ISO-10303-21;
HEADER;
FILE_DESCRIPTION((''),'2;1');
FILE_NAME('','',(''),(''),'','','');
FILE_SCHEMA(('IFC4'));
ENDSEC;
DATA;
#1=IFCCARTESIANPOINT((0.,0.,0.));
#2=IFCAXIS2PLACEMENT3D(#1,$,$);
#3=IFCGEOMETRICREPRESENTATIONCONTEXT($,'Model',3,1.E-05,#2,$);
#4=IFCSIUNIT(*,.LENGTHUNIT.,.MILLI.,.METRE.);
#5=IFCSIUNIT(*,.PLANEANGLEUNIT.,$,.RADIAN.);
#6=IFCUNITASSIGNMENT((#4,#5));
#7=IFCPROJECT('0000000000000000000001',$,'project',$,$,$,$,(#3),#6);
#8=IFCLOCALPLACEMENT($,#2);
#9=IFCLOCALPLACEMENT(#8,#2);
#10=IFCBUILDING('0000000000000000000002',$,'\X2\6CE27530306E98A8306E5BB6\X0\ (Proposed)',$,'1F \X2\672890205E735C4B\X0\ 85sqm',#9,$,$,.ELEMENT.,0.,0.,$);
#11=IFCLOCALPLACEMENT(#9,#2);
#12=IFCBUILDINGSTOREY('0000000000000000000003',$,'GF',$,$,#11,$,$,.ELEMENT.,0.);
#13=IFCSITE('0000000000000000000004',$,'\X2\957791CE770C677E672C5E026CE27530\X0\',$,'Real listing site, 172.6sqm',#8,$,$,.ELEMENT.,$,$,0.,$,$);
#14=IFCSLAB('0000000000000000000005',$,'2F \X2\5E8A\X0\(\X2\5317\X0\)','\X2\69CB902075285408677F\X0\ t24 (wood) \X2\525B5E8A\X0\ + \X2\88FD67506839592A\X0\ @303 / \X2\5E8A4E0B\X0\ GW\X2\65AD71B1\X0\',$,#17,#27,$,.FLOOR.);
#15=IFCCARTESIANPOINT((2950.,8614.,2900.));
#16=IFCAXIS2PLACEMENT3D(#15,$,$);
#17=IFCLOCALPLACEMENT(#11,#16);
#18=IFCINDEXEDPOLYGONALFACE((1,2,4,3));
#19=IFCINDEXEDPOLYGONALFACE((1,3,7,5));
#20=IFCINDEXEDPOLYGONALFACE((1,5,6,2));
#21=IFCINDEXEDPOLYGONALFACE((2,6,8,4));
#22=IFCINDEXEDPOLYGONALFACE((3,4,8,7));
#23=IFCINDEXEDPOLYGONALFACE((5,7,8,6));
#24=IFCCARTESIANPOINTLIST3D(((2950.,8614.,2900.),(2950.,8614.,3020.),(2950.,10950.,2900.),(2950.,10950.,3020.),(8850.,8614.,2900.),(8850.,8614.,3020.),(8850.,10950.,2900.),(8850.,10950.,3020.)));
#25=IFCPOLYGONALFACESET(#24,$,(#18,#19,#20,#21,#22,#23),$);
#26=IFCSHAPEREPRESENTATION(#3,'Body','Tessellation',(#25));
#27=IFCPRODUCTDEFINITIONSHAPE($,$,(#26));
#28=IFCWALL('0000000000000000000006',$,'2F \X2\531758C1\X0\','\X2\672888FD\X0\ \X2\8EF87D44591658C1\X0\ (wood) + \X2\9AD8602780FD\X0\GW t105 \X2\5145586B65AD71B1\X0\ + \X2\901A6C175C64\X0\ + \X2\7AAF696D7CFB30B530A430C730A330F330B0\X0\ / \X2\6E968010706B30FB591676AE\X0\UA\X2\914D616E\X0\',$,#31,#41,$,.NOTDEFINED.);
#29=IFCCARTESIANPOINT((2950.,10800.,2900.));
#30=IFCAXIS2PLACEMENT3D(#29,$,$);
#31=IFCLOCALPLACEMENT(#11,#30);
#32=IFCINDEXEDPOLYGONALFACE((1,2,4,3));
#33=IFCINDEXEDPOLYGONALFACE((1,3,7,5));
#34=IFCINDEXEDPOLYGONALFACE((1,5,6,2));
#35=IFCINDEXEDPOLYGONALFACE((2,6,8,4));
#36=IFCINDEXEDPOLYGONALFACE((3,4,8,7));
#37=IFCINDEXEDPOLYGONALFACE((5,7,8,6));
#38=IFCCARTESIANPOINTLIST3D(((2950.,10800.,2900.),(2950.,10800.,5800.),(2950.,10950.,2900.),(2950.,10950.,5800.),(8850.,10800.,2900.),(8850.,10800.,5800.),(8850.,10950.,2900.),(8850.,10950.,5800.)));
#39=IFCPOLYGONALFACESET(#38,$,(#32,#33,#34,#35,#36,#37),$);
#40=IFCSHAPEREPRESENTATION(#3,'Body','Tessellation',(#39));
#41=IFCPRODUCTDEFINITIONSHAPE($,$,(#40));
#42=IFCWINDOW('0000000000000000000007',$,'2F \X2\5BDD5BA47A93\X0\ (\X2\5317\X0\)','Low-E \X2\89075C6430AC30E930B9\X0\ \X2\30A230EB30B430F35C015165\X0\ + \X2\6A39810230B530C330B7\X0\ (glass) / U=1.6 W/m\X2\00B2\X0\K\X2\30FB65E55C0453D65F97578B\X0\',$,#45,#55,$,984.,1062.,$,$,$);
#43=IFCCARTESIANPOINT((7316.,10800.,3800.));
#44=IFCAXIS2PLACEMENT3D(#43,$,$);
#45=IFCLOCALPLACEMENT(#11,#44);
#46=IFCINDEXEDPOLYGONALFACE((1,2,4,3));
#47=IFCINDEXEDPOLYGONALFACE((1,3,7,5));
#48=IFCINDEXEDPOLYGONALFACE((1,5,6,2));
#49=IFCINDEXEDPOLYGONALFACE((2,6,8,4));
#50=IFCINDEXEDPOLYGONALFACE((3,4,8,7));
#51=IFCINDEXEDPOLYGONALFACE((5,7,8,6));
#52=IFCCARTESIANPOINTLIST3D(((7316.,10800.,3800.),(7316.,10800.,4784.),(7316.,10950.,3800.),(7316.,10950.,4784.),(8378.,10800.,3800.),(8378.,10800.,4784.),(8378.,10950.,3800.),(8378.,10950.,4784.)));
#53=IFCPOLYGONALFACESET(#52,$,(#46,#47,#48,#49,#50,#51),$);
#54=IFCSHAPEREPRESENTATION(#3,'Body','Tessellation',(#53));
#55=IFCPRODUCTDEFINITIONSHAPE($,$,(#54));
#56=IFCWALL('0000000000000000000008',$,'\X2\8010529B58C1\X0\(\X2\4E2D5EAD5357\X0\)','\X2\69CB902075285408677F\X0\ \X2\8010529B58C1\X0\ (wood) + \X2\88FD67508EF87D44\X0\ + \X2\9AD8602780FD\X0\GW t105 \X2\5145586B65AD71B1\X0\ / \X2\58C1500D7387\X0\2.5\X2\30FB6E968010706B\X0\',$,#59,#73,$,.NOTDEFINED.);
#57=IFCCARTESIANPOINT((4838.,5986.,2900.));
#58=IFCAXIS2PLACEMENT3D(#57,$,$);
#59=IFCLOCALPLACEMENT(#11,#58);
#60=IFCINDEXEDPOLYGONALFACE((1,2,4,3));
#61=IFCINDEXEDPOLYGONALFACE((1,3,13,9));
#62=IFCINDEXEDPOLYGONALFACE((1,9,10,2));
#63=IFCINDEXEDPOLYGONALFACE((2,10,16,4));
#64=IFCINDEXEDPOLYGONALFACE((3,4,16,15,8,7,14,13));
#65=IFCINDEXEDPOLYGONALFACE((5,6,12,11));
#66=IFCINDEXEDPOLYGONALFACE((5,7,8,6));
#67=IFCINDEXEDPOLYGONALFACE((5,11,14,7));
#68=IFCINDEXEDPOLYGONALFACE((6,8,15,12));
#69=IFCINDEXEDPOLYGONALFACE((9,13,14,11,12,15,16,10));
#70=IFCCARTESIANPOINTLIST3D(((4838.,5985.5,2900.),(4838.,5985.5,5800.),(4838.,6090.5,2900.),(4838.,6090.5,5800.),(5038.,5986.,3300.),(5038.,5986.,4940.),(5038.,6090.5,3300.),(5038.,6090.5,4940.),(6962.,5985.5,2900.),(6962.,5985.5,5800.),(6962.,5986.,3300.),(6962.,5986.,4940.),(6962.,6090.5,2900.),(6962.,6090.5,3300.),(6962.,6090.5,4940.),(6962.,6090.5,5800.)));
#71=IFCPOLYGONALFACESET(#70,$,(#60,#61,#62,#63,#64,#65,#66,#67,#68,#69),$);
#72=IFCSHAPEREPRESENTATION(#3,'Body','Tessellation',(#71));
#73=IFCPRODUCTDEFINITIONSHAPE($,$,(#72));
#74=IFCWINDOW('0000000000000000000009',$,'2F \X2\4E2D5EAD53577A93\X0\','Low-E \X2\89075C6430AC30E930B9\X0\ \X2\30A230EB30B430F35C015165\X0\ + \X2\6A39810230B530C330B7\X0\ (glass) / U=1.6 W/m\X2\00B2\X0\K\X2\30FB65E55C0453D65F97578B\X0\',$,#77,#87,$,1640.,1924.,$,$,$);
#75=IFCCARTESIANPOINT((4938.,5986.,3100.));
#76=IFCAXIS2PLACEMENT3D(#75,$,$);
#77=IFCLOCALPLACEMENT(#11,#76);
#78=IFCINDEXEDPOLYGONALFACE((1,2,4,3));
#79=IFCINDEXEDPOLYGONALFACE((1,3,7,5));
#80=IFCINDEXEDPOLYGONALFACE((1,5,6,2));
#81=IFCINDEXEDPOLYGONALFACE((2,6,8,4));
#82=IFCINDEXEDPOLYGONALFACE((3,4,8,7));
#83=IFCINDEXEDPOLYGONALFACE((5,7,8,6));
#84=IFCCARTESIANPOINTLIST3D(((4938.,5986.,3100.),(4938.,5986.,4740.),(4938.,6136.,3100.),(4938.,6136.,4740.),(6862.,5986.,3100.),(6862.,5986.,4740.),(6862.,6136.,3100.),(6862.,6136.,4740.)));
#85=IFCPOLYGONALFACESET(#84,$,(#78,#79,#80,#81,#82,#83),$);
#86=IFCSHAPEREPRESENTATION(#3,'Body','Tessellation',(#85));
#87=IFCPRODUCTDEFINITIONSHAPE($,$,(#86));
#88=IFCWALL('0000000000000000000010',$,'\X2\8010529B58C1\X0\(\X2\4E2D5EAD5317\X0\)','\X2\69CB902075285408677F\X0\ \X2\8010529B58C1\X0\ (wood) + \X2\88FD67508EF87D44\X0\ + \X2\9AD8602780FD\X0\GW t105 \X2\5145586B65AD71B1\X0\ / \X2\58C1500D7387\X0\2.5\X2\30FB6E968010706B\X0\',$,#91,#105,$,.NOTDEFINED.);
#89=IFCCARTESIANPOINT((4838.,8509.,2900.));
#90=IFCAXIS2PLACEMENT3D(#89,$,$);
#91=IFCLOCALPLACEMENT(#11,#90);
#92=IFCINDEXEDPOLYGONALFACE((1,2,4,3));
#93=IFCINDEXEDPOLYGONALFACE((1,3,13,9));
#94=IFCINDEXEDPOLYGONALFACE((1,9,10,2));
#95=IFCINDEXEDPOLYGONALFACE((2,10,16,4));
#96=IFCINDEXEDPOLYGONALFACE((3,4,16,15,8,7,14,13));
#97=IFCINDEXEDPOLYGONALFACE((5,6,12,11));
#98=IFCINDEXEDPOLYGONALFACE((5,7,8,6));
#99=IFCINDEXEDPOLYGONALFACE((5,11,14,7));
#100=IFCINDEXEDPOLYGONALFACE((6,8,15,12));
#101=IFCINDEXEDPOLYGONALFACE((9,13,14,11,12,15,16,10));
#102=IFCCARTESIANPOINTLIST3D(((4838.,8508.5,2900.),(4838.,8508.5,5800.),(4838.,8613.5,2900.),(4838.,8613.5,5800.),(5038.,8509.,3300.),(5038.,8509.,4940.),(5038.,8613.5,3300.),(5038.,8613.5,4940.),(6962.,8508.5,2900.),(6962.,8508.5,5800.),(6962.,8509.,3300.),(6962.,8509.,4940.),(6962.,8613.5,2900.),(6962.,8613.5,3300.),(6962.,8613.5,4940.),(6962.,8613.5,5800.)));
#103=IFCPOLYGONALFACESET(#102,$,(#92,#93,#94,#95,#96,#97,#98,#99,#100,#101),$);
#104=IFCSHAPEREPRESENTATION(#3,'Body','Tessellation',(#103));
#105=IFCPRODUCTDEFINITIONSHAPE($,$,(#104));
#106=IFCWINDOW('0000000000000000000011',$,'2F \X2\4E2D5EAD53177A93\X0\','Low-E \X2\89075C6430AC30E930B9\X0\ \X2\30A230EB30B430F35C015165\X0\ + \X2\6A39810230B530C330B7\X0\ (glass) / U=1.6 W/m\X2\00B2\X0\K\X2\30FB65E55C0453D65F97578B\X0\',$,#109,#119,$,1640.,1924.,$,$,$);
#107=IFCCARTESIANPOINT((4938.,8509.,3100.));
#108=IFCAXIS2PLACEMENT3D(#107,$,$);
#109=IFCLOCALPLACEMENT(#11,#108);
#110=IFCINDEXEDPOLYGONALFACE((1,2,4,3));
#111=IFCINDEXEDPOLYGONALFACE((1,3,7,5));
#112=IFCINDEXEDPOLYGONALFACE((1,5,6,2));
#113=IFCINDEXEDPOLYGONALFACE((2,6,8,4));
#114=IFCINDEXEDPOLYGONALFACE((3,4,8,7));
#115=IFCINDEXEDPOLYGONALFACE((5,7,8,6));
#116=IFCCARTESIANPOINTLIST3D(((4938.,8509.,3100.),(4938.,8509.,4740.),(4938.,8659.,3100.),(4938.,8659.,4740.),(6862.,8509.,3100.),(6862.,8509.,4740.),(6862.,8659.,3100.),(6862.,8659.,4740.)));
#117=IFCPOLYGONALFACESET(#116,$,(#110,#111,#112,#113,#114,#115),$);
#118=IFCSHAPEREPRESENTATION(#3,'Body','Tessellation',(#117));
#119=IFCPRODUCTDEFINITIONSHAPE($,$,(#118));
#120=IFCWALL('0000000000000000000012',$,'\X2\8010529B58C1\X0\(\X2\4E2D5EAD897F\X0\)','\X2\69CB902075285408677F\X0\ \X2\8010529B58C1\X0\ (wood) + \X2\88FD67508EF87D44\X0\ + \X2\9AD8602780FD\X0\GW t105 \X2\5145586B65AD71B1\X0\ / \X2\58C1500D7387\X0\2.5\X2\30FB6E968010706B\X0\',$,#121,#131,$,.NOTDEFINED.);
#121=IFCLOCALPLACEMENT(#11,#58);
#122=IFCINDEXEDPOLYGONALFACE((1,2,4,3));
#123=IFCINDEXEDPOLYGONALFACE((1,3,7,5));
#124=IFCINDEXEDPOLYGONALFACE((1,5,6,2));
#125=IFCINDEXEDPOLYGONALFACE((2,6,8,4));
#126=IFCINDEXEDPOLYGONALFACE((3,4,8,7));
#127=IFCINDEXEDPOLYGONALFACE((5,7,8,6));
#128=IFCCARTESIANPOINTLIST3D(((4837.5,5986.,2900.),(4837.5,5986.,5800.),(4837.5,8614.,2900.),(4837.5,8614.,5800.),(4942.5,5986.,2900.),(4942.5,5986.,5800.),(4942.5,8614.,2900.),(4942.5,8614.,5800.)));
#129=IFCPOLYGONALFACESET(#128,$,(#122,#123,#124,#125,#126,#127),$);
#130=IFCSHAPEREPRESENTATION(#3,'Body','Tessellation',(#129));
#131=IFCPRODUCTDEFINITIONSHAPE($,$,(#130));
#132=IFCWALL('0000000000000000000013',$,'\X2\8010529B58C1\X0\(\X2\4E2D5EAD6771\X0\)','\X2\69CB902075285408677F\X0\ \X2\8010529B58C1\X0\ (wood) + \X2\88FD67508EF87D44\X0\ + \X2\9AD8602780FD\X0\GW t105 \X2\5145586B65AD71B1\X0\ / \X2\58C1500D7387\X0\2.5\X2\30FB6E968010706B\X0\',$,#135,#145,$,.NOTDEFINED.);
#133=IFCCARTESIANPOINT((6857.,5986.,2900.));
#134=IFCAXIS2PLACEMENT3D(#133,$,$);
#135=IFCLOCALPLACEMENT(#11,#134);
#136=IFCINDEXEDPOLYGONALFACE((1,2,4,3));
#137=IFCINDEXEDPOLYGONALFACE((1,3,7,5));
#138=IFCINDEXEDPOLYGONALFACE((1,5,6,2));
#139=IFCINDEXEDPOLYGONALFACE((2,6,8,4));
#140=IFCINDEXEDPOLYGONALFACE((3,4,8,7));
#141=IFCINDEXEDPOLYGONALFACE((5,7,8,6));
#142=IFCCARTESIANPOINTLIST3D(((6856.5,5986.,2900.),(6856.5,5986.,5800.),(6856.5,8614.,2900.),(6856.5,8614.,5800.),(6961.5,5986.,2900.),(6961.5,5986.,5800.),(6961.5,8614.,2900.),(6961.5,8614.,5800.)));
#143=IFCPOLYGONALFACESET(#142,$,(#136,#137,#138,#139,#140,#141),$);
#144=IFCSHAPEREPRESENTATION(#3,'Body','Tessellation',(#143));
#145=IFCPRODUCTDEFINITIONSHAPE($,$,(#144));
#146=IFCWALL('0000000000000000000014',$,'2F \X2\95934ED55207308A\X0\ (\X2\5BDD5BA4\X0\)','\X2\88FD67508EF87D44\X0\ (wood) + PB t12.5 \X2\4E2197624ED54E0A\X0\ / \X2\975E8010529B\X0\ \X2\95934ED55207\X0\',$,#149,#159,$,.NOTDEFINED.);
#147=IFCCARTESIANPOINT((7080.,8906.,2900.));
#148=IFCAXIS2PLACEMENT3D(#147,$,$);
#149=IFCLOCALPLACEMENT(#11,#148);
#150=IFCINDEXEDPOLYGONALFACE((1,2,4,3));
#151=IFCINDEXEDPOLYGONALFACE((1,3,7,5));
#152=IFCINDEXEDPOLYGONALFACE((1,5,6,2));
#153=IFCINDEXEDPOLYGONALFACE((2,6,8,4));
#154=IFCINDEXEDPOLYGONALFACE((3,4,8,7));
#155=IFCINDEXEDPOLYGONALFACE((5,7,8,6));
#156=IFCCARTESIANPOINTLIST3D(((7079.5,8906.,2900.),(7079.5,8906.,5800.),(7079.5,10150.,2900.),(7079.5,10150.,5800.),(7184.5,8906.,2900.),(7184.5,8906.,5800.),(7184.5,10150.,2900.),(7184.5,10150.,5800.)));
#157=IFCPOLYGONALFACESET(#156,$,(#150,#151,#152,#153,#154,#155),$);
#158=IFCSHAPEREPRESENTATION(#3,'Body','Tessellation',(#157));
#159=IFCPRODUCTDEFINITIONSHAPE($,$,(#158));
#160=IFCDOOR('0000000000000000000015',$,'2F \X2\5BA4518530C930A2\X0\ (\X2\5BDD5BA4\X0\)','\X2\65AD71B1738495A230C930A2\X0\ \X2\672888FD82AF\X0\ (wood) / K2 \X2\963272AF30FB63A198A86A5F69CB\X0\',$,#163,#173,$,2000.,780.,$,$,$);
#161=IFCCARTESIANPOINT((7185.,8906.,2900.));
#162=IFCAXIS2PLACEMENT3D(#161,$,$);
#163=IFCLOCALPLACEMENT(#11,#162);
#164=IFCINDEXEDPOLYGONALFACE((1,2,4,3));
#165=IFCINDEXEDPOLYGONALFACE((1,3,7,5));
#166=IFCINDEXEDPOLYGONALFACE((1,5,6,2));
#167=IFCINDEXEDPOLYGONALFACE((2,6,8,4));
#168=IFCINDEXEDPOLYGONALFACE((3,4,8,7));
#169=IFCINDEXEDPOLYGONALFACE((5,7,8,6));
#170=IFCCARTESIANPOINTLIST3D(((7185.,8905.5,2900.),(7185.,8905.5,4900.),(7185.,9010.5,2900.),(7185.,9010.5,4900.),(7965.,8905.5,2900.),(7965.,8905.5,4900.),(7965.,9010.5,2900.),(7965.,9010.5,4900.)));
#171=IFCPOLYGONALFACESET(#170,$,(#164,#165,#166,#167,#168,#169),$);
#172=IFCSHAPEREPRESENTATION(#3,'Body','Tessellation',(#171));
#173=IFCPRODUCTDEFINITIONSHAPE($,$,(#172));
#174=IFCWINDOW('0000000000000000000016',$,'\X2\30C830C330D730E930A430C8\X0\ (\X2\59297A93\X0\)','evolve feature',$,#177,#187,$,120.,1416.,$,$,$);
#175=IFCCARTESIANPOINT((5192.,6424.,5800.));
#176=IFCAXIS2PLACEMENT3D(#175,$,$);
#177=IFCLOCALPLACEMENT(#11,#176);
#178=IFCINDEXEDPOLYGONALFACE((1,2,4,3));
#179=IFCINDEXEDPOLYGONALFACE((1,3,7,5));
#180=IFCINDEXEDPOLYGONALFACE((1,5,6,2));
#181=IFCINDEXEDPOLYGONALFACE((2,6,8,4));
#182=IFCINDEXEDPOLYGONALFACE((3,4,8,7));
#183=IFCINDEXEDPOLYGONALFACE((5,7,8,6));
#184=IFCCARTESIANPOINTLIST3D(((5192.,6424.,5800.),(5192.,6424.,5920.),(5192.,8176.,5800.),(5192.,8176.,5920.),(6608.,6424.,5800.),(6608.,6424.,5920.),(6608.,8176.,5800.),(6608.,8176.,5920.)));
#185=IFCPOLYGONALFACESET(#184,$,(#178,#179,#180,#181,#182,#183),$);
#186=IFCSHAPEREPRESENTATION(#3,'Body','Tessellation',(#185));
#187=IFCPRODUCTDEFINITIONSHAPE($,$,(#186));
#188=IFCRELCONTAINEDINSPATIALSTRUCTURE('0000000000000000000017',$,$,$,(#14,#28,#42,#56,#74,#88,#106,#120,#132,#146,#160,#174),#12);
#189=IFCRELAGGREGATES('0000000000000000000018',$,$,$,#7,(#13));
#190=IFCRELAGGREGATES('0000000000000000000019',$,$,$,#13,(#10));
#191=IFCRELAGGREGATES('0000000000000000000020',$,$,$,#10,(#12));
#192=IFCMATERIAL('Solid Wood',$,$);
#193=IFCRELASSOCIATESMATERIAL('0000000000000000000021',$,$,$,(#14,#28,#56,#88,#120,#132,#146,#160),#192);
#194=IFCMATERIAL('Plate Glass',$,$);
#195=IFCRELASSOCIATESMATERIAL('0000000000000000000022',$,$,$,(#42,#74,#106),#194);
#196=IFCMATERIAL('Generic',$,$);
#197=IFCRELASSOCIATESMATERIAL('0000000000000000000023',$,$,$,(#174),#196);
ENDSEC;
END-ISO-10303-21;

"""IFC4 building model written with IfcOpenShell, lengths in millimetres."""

from ifc_helpers import new_model, si_unit, frame, frame_2d, origin, place, context, project, spatial, rectangle, extrude, material, element, fill, save


model = new_model("IFC4")

# Units and contexts
model_context = context("Model", 3, precision=1e-05, world=origin())
ifc_project = project(units=[si_unit("LENGTHUNIT", "METRE", prefix="MILLI"), si_unit("PLANEANGLEUNIT", "RADIAN")], contexts=[model_context])

# Site, building, storey
site_placement = place(None, origin())
site = spatial("IfcSite", under=ifc_project, at=site_placement, Name="長野県松本市波田", ObjectType="Real listing site, 172.6sqm", CompositionType="ELEMENT", RefElevation=0.0)
building_placement = place(site_placement, origin())
building = spatial("IfcBuilding", under=site, at=building_placement, Name="波田の風の家 (Proposed)", ObjectType="1F 木造平屋 85sqm", CompositionType="ELEMENT", ElevationOfRefHeight=0.0, ElevationOfTerrain=0.0)
storey_placement = place(building_placement, origin())
storey = spatial("IfcBuildingStorey", under=building, at=storey_placement, Name="GF", CompositionType="ELEMENT", Elevation=0.0)

# Slab
ifc_material_1 = material(Name="Solid Wood")
slab_placement = place(storey_placement, frame((2950.0, 8614.0, 2900.0)))
element("IfcSlab", 1, at=slab_placement, inside=storey, material=ifc_material_1, Name="2F 床(北)", Description="構造用合板 t24 (wood) 剛床 + 製材根太 @303 / 床下 GW断熱", PredefinedType="FLOOR", context=model_context, shape_type="SweptSolid", body=[
    extrude(rectangle(XDim=5900.0, YDim=2336.0, at=frame_2d((2950.0, 1168.0))), frame((2950.0, 8614.0, 2900.0)), (0.0, 0.0, 1.0), 120.0),
])

# Walls, openings, windows
wall_1_placement = place(storey_placement, frame((2950.0, 10800.0, 2900.0)))
wall_1 = element("IfcWall", 2, at=wall_1_placement, inside=storey, material=ifc_material_1, Name="2F 北壁", Description="木製 軸組外壁 (wood) + 高性能GW t105 充填断熱 + 通気層 + 窯業系サイディング / 準耐火・外皮UA配慮", PredefinedType="NOTDEFINED", context=model_context, shape_type="SweptSolid", body=[
    extrude(rectangle(XDim=5900.0, YDim=150.0, at=frame_2d((2950.0, 75.0))), frame((2950.0, 10800.0, 2900.0)), (0.0, 0.0, 1.0), 2900.0),
])
opening_1_placement = place(storey_placement, frame((7316.0, 10800.0, 3800.0)))
opening_1 = element("IfcOpeningElement", 3, at=opening_1_placement, cuts=wall_1, PredefinedType="NOTDEFINED", context=model_context, shape_type="SweptSolid", body=[
    extrude(rectangle(XDim=1062.0, YDim=150.0, at=frame_2d((531.0, 75.0))), frame((7316.0, 10800.0, 3800.0)), (0.0, 0.0, 1.0), 984.0),
])
ifc_material_2 = material(Name="Plate Glass")
window_1_placement = place(storey_placement, frame((7316.0, 10800.0, 3800.0)))
window_1 = element("IfcWindow", 4, at=window_1_placement, inside=storey, material=ifc_material_2, Name="2F 寝室窓 (北)", Description="Low-E 複層ガラス アルゴン封入 + 樹脂サッシ (glass) / U=1.6 W/m²K・日射取得型", OverallHeight=984.0, OverallWidth=1062.0, context=model_context, shape_type="SweptSolid", body=[
    extrude(rectangle(XDim=1062.0, YDim=150.0, at=frame_2d((531.0, 75.0))), frame((7316.0, 10800.0, 3800.0)), (0.0, 0.0, 1.0), 984.0),
])
fill(opening_1, window_1)
wall_2_placement = place(storey_placement, frame((4838.0, 5986.0, 2900.0)))
wall_2 = element("IfcWall", 5, at=wall_2_placement, inside=storey, material=ifc_material_1, Name="耐力壁(中庭南)", Description="構造用合板 耐力壁 (wood) + 製材軸組 + 高性能GW t105 充填断熱 / 壁倍率2.5・準耐火", PredefinedType="NOTDEFINED", context=model_context, shape_type="SweptSolid", body=[
    extrude(rectangle(XDim=2124.0, YDim=105.0, at=frame_2d((1062.0, 52.0))), frame((4838.0, 5986.0, 2900.0)), (0.0, 0.0, 1.0), 2900.0),
])
opening_2_placement = place(storey_placement, frame((4938.0, 5986.0, 3100.0)))
opening_2 = element("IfcOpeningElement", 6, at=opening_2_placement, cuts=wall_2, PredefinedType="NOTDEFINED", context=model_context, shape_type="SweptSolid", body=[
    extrude(rectangle(XDim=1924.0, YDim=150.0, at=frame_2d((962.0, 75.0))), frame((4938.0, 5986.0, 3100.0)), (0.0, 0.0, 1.0), 1640.0),
])
window_2_placement = place(storey_placement, frame((4938.0, 5986.0, 3100.0)))
window_2 = element("IfcWindow", 7, at=window_2_placement, inside=storey, material=ifc_material_2, Name="2F 中庭南窓", Description="Low-E 複層ガラス アルゴン封入 + 樹脂サッシ (glass) / U=1.6 W/m²K・日射取得型", OverallHeight=1640.0, OverallWidth=1924.0, context=model_context, shape_type="SweptSolid", body=[
    extrude(rectangle(XDim=1924.0, YDim=150.0, at=frame_2d((962.0, 75.0))), frame((4938.0, 5986.0, 3100.0)), (0.0, 0.0, 1.0), 1640.0),
])
fill(opening_2, window_2)
wall_3_placement = place(storey_placement, frame((4838.0, 8509.0, 2900.0)))
wall_3 = element("IfcWall", 8, at=wall_3_placement, inside=storey, material=ifc_material_1, Name="耐力壁(中庭北)", Description="構造用合板 耐力壁 (wood) + 製材軸組 + 高性能GW t105 充填断熱 / 壁倍率2.5・準耐火", PredefinedType="NOTDEFINED", context=model_context, shape_type="SweptSolid", body=[
    extrude(rectangle(XDim=2124.0, YDim=105.0, at=frame_2d((1062.0, 52.0))), frame((4838.0, 8509.0, 2900.0)), (0.0, 0.0, 1.0), 2900.0),
])
opening_3_placement = place(storey_placement, frame((4938.0, 8509.0, 3100.0)))
opening_3 = element("IfcOpeningElement", 9, at=opening_3_placement, cuts=wall_3, PredefinedType="NOTDEFINED", context=model_context, shape_type="SweptSolid", body=[
    extrude(rectangle(XDim=1924.0, YDim=150.0, at=frame_2d((962.0, 75.0))), frame((4938.0, 8509.0, 3100.0)), (0.0, 0.0, 1.0), 1640.0),
])
window_3_placement = place(storey_placement, frame((4938.0, 8509.0, 3100.0)))
window_3 = element("IfcWindow", 10, at=window_3_placement, inside=storey, material=ifc_material_2, Name="2F 中庭北窓", Description="Low-E 複層ガラス アルゴン封入 + 樹脂サッシ (glass) / U=1.6 W/m²K・日射取得型", OverallHeight=1640.0, OverallWidth=1924.0, context=model_context, shape_type="SweptSolid", body=[
    extrude(rectangle(XDim=1924.0, YDim=150.0, at=frame_2d((962.0, 75.0))), frame((4938.0, 8509.0, 3100.0)), (0.0, 0.0, 1.0), 1640.0),
])
fill(opening_3, window_3)

# Walls
wall_4_placement = place(storey_placement, frame((4838.0, 5986.0, 2900.0)))
element("IfcWall", 11, at=wall_4_placement, inside=storey, material=ifc_material_1, Name="耐力壁(中庭西)", Description="構造用合板 耐力壁 (wood) + 製材軸組 + 高性能GW t105 充填断熱 / 壁倍率2.5・準耐火", PredefinedType="NOTDEFINED", context=model_context, shape_type="SweptSolid", body=[
    extrude(rectangle(XDim=105.0, YDim=2628.0, at=frame_2d((52.0, 1314.0))), frame((4838.0, 5986.0, 2900.0)), (0.0, 0.0, 1.0), 2900.0),
])
wall_5_placement = place(storey_placement, frame((6857.0, 5986.0, 2900.0)))
element("IfcWall", 12, at=wall_5_placement, inside=storey, material=ifc_material_1, Name="耐力壁(中庭東)", Description="構造用合板 耐力壁 (wood) + 製材軸組 + 高性能GW t105 充填断熱 / 壁倍率2.5・準耐火", PredefinedType="NOTDEFINED", context=model_context, shape_type="SweptSolid", body=[
    extrude(rectangle(XDim=105.0, YDim=2628.0, at=frame_2d((52.0, 1314.0))), frame((6857.0, 5986.0, 2900.0)), (0.0, 0.0, 1.0), 2900.0),
])
wall_6_placement = place(storey_placement, frame((7080.0, 8906.0, 2900.0)))
element("IfcWall", 13, at=wall_6_placement, inside=storey, material=ifc_material_1, Name="2F 間仕切り (寝室)", Description="製材軸組 (wood) + PB t12.5 両面仕上 / 非耐力 間仕切", PredefinedType="NOTDEFINED", context=model_context, shape_type="SweptSolid", body=[
    extrude(rectangle(XDim=105.0, YDim=1244.0, at=frame_2d((52.0, 622.0))), frame((7080.0, 8906.0, 2900.0)), (0.0, 0.0, 1.0), 2900.0),
])

# Door
door_placement = place(storey_placement, frame((7185.0, 8906.0, 2900.0)))
element("IfcDoor", 14, at=door_placement, inside=storey, material=ifc_material_1, Name="2F 室内ドア (寝室)", Description="断熱玄関ドア 木製芯 (wood) / K2 防犯・採風機構", OverallHeight=2000.0, OverallWidth=780.0, context=model_context, shape_type="SweptSolid", body=[
    extrude(rectangle(XDim=780.0, YDim=105.0, at=frame_2d((390.0, 52.0))), frame((7185.0, 8906.0, 2900.0)), (0.0, 0.0, 1.0), 2000.0),
])

# Window
ifc_material_3 = material(Name="Generic")
window_4_placement = place(storey_placement, frame((5192.0, 6424.0, 5800.0)))
element("IfcWindow", 15, at=window_4_placement, inside=storey, material=ifc_material_3, Name="トップライト (天窓)", Description="evolve feature", OverallHeight=120.0, OverallWidth=1416.0, context=model_context, shape_type="SweptSolid", body=[
    extrude(rectangle(XDim=1416.0, YDim=1752.0, at=frame_2d((708.0, 876.0))), frame((5192.0, 6424.0, 5800.0)), (0.0, 0.0, 1.0), 120.0),
])

save(model, "model.ifc")
